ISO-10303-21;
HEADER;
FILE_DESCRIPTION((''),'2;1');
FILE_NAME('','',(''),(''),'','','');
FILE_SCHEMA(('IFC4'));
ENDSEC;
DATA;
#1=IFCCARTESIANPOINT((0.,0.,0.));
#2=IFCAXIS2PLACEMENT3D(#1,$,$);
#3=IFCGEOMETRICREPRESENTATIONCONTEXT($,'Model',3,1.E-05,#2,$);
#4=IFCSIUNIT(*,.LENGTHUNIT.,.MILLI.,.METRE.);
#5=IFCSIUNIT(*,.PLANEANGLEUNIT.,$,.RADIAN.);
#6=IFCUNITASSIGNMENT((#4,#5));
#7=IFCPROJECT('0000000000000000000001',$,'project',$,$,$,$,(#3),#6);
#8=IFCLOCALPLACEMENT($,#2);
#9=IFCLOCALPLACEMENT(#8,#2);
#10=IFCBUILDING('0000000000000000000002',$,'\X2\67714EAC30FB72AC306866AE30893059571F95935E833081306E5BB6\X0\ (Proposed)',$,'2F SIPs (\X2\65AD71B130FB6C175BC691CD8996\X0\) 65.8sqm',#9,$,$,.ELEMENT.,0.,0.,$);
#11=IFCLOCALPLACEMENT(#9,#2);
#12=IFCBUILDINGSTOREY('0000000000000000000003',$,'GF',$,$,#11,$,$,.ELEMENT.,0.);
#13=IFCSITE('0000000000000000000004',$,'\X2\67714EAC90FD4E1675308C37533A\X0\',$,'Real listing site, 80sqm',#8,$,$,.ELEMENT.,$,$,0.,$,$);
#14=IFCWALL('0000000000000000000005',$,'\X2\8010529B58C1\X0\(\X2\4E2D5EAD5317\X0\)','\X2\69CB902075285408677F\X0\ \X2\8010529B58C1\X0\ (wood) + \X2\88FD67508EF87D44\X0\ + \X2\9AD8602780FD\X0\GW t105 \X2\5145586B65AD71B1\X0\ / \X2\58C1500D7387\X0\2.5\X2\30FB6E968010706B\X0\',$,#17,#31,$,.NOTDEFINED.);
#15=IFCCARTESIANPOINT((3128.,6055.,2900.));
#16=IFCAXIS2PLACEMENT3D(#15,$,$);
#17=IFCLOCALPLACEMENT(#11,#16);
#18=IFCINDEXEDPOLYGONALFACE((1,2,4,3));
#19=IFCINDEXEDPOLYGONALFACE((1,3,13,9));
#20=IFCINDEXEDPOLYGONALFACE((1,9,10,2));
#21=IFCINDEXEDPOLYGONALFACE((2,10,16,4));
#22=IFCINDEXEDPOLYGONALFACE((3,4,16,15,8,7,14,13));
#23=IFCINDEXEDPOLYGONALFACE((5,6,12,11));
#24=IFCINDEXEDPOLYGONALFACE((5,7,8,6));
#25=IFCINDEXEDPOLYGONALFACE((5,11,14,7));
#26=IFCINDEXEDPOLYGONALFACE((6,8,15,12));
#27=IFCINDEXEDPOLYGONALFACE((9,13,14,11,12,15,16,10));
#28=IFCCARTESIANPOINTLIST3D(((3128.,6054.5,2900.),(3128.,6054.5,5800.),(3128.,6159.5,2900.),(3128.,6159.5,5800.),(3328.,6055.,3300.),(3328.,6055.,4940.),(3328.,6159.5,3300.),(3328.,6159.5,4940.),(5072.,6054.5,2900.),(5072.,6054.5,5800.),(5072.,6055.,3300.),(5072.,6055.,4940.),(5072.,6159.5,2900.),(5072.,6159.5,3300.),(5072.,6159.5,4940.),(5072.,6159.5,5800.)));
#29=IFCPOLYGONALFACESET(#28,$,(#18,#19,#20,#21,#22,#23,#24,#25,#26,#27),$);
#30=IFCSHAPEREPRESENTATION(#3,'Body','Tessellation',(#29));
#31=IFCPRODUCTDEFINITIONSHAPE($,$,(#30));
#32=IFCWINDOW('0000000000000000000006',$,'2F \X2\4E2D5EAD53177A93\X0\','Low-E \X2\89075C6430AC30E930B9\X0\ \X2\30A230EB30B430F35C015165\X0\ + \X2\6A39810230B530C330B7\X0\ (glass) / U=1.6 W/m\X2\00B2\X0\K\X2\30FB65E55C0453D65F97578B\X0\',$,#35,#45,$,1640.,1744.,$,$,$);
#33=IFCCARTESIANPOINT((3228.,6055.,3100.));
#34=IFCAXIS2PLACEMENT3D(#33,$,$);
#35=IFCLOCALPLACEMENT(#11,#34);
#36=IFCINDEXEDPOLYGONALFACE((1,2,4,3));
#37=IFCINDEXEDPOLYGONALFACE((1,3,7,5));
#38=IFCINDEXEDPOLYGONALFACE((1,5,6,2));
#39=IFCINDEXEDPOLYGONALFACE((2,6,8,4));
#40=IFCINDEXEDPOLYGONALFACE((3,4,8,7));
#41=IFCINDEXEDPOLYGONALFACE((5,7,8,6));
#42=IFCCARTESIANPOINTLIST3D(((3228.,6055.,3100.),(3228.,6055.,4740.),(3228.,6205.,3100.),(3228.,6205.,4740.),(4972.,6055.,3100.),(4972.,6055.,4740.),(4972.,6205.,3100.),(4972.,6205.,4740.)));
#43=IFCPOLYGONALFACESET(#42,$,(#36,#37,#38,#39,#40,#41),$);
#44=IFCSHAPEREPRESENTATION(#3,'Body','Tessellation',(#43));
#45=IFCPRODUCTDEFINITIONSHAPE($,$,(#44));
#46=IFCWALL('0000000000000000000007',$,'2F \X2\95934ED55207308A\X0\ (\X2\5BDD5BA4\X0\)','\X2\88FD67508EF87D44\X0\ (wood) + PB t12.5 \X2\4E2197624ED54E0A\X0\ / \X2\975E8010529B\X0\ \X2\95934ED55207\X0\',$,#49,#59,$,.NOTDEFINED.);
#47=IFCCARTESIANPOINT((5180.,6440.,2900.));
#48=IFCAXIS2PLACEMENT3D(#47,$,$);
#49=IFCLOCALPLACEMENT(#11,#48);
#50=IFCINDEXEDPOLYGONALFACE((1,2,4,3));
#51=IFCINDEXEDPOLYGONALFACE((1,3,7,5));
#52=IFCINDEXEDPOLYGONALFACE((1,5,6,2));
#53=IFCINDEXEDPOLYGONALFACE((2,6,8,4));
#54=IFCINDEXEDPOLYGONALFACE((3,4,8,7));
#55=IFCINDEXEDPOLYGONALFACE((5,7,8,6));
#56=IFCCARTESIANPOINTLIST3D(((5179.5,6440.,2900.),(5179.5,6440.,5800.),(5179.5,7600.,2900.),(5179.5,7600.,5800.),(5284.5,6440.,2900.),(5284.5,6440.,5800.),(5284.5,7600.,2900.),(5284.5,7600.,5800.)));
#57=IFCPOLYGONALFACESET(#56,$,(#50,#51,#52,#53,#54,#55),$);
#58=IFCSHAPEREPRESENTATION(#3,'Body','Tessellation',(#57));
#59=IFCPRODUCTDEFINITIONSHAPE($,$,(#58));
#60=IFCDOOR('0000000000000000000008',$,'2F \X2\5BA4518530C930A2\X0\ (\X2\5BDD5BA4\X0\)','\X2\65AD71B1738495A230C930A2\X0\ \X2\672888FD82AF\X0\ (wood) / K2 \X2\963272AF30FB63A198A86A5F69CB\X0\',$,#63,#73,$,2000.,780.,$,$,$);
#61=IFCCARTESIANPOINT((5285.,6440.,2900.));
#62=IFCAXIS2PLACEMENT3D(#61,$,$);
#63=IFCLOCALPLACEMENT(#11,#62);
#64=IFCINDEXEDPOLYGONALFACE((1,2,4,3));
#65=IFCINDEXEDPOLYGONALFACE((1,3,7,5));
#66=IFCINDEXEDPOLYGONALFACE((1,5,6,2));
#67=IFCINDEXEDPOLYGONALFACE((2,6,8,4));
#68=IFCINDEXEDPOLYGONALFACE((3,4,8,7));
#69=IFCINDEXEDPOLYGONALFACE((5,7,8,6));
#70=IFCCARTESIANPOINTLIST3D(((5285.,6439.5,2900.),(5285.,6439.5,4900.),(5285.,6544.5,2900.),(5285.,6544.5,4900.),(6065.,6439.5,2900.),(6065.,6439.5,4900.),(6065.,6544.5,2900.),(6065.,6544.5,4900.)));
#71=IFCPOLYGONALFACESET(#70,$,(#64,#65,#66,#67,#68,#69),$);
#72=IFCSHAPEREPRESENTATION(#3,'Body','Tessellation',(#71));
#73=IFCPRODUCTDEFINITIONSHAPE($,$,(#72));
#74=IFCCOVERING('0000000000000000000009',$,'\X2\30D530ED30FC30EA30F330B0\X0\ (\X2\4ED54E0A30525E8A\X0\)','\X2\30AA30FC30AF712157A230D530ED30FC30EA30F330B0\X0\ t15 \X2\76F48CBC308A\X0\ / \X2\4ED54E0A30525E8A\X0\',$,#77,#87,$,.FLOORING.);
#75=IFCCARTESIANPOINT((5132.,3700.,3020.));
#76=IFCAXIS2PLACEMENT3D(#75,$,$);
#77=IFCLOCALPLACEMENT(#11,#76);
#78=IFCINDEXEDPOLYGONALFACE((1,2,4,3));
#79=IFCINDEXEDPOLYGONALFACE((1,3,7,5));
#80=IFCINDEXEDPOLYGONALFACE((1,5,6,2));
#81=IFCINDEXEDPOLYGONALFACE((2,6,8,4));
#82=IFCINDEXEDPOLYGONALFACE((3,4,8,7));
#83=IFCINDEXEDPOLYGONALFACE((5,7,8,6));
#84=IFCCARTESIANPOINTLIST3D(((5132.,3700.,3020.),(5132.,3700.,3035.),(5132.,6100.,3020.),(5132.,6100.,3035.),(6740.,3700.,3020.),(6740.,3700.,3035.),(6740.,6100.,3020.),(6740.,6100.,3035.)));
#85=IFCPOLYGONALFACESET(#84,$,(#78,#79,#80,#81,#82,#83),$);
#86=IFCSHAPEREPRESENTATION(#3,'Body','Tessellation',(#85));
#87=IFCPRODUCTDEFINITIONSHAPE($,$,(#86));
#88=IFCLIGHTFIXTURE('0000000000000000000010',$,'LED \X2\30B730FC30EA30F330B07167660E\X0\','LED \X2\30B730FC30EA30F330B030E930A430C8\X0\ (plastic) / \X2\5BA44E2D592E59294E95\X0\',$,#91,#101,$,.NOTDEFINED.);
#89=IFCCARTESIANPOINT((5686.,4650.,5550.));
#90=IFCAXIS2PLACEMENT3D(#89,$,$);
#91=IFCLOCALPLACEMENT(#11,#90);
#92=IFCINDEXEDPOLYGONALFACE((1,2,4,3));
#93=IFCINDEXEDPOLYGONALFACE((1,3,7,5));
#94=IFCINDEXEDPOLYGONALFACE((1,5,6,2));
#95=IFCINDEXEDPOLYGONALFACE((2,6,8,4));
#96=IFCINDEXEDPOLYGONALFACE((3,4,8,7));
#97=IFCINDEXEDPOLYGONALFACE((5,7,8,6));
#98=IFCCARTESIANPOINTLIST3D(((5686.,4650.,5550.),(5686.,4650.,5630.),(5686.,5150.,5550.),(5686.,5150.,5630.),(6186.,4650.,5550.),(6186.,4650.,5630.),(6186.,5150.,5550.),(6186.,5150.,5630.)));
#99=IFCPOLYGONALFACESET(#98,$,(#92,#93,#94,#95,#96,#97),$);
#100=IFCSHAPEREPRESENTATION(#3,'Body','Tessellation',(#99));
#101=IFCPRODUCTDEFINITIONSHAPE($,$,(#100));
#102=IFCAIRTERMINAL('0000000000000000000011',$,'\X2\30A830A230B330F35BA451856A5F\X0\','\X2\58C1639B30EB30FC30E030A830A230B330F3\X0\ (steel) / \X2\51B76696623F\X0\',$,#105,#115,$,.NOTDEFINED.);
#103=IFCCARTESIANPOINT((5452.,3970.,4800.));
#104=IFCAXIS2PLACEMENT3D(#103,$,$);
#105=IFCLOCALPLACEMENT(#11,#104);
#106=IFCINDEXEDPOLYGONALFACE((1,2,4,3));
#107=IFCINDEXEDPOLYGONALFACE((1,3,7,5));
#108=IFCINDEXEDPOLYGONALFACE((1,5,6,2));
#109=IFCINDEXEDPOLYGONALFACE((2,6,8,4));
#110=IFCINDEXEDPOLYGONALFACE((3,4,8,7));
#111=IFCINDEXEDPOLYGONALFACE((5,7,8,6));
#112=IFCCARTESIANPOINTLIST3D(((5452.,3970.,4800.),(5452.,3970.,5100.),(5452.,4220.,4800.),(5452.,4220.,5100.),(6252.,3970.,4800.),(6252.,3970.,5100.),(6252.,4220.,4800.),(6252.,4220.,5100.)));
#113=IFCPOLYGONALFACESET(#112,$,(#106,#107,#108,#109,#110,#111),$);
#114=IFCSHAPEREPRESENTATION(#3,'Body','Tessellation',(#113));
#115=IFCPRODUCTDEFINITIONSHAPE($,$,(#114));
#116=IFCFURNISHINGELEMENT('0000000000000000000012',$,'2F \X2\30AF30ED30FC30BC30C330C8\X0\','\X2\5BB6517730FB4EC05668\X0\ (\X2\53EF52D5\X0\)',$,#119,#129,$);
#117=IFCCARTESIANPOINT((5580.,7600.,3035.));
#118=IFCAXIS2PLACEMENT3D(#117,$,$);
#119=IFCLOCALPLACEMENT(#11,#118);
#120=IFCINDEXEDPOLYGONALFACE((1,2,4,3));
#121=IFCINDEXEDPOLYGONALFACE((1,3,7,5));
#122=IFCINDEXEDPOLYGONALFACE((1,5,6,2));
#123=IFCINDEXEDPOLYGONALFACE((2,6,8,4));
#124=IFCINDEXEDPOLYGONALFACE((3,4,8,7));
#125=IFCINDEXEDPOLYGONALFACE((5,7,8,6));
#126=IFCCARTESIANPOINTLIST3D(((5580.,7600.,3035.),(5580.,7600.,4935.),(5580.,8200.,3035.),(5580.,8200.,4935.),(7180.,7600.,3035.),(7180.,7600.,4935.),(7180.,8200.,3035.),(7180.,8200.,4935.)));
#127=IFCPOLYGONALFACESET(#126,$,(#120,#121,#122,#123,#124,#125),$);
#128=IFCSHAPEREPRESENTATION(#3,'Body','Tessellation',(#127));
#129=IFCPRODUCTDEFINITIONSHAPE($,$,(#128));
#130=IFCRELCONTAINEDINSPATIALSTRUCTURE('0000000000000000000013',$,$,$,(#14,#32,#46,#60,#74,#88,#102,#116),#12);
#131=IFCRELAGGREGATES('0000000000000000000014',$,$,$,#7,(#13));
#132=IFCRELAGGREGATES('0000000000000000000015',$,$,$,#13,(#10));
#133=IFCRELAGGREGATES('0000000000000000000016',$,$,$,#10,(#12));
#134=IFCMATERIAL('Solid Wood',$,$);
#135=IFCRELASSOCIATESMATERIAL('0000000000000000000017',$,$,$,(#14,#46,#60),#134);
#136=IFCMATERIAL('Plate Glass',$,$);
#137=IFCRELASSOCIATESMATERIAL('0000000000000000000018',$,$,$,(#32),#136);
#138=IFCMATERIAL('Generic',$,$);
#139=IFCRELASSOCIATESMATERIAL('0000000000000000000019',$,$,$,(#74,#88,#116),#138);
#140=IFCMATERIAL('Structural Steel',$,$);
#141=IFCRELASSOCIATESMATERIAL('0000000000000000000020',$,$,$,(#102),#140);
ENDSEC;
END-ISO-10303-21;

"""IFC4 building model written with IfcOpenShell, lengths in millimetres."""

from ifc_helpers import new_model, si_unit, frame, frame_2d, origin, place, context, project, spatial, rectangle, extrude, material, element, fill, save


model = new_model("IFC4")

# Units and contexts
model_context = context("Model", 3, precision=1e-05, world=origin())
ifc_project = project(units=[si_unit("LENGTHUNIT", "METRE", prefix="MILLI"), si_unit("PLANEANGLEUNIT", "RADIAN")], contexts=[model_context])

# Site, building, storey
site_placement = place(None, origin())
site = spatial("IfcSite", under=ifc_project, at=site_placement, Name="東京都世田谷区", ObjectType="Real listing site, 80sqm", CompositionType="ELEMENT", RefElevation=0.0)
building_placement = place(site_placement, origin())
building = spatial("IfcBuilding", under=site, at=building_placement, Name="東京・犬と暮らす土間広めの家 (Proposed)", ObjectType="2F SIPs (断熱・気密重視) 65.8sqm", CompositionType="ELEMENT", ElevationOfRefHeight=0.0, ElevationOfTerrain=0.0)
storey_placement = place(building_placement, origin())
storey = spatial("IfcBuildingStorey", under=building, at=storey_placement, Name="GF", CompositionType="ELEMENT", Elevation=0.0)

# Shared definitions
ifc_material_1 = material(Name="Solid Wood")

# Wall, opening, window
wall_1_placement = place(storey_placement, frame((3128.0, 6055.0, 2900.0)))
wall_1 = element("IfcWall", 1, at=wall_1_placement, inside=storey, material=ifc_material_1, Name="耐力壁(中庭北)", Description="構造用合板 耐力壁 (wood) + 製材軸組 + 高性能GW t105 充填断熱 / 壁倍率2.5・準耐火", PredefinedType="NOTDEFINED", context=model_context, shape_type="SweptSolid", body=[
    extrude(rectangle(XDim=1944.0, YDim=105.0, at=frame_2d((972.0, 52.0))), frame((3128.0, 6055.0, 2900.0)), (0.0, 0.0, 1.0), 2900.0),
])
opening_placement = place(storey_placement, frame((3228.0, 6055.0, 3100.0)))
opening = element("IfcOpeningElement", 2, at=opening_placement, cuts=wall_1, PredefinedType="NOTDEFINED", context=model_context, shape_type="SweptSolid", body=[
    extrude(rectangle(XDim=1744.0, YDim=150.0, at=frame_2d((872.0, 75.0))), frame((3228.0, 6055.0, 3100.0)), (0.0, 0.0, 1.0), 1640.0),
])
ifc_material_2 = material(Name="Plate Glass")
window_placement = place(storey_placement, frame((3228.0, 6055.0, 3100.0)))
window = element("IfcWindow", 3, at=window_placement, inside=storey, material=ifc_material_2, Name="2F 中庭北窓", Description="Low-E 複層ガラス アルゴン封入 + 樹脂サッシ (glass) / U=1.6 W/m²K・日射取得型", OverallHeight=1640.0, OverallWidth=1744.0, context=model_context, shape_type="SweptSolid", body=[
    extrude(rectangle(XDim=1744.0, YDim=150.0, at=frame_2d((872.0, 75.0))), frame((3228.0, 6055.0, 3100.0)), (0.0, 0.0, 1.0), 1640.0),
])
fill(opening, window)

# Wall
wall_2_placement = place(storey_placement, frame((5180.0, 6440.0, 2900.0)))
element("IfcWall", 4, at=wall_2_placement, inside=storey, material=ifc_material_1, Name="2F 間仕切り (寝室)", Description="製材軸組 (wood) + PB t12.5 両面仕上 / 非耐力 間仕切", PredefinedType="NOTDEFINED", context=model_context, shape_type="SweptSolid", body=[
    extrude(rectangle(XDim=105.0, YDim=1160.0, at=frame_2d((52.0, 580.0))), frame((5180.0, 6440.0, 2900.0)), (0.0, 0.0, 1.0), 2900.0),
])

# Door
door_placement = place(storey_placement, frame((5285.0, 6440.0, 2900.0)))
element("IfcDoor", 5, at=door_placement, inside=storey, material=ifc_material_1, Name="2F 室内ドア (寝室)", Description="断熱玄関ドア 木製芯 (wood) / K2 防犯・採風機構", OverallHeight=2000.0, OverallWidth=780.0, context=model_context, shape_type="SweptSolid", body=[
    extrude(rectangle(XDim=780.0, YDim=105.0, at=frame_2d((390.0, 52.0))), frame((5285.0, 6440.0, 2900.0)), (0.0, 0.0, 1.0), 2000.0),
])

# Covering
ifc_material_3 = material(Name="Generic")
covering_placement = place(storey_placement, frame((5132.0, 3700.0, 3020.0)))
element("IfcCovering", 6, at=covering_placement, inside=storey, material=ifc_material_3, Name="フローリング (仕上げ床)", Description="オーク無垢フローリング t15 直貼り / 仕上げ床", PredefinedType="FLOORING", context=model_context, shape_type="SweptSolid", body=[
    extrude(rectangle(XDim=1608.0, YDim=2400.0, at=frame_2d((804.0, 1200.0))), frame((5132.0, 3700.0, 3020.0)), (0.0, 0.0, 1.0), 15.0),
])

# Light fixture
light_fixture_placement = place(storey_placement, frame((5686.0, 4650.0, 5550.0)))
element("IfcLightFixture", 7, at=light_fixture_placement, inside=storey, material=ifc_material_3, Name="LED シーリング照明", Description="LED シーリングライト (plastic) / 室中央天井", PredefinedType="NOTDEFINED", context=model_context, shape_type="SweptSolid", body=[
    extrude(rectangle(XDim=500.0, YDim=500.0, at=frame_2d((250.0, 250.0))), frame((5686.0, 4650.0, 5550.0)), (0.0, 0.0, 1.0), 80.0),
])

# Air terminal
ifc_material_4 = material(Name="Structural Steel")
air_terminal_placement = place(storey_placement, frame((5452.0, 3970.0, 4800.0)))
element("IfcAirTerminal", 8, at=air_terminal_placement, inside=storey, material=ifc_material_4, Name="エアコン室内機", Description="壁掛ルームエアコン (steel) / 冷暖房", PredefinedType="NOTDEFINED", context=model_context, shape_type="SweptSolid", body=[
    extrude(rectangle(XDim=800.0, YDim=250.0, at=frame_2d((400.0, 125.0))), frame((5452.0, 3970.0, 4800.0)), (0.0, 0.0, 1.0), 300.0),
])

# Furnishing element
furnishing_placement = place(storey_placement, frame((5580.0, 7600.0, 3035.0)))
element("IfcFurnishingElement", 9, at=furnishing_placement, inside=storey, material=ifc_material_3, Name="2F クローゼット", Description="家具・什器 (可動)", context=model_context, shape_type="SweptSolid", body=[
    extrude(rectangle(XDim=1600.0, YDim=600.0, at=frame_2d((800.0, 300.0))), frame((5580.0, 7600.0, 3035.0)), (0.0, 0.0, 1.0), 1900.0),
])

save(model, "model.ifc")
